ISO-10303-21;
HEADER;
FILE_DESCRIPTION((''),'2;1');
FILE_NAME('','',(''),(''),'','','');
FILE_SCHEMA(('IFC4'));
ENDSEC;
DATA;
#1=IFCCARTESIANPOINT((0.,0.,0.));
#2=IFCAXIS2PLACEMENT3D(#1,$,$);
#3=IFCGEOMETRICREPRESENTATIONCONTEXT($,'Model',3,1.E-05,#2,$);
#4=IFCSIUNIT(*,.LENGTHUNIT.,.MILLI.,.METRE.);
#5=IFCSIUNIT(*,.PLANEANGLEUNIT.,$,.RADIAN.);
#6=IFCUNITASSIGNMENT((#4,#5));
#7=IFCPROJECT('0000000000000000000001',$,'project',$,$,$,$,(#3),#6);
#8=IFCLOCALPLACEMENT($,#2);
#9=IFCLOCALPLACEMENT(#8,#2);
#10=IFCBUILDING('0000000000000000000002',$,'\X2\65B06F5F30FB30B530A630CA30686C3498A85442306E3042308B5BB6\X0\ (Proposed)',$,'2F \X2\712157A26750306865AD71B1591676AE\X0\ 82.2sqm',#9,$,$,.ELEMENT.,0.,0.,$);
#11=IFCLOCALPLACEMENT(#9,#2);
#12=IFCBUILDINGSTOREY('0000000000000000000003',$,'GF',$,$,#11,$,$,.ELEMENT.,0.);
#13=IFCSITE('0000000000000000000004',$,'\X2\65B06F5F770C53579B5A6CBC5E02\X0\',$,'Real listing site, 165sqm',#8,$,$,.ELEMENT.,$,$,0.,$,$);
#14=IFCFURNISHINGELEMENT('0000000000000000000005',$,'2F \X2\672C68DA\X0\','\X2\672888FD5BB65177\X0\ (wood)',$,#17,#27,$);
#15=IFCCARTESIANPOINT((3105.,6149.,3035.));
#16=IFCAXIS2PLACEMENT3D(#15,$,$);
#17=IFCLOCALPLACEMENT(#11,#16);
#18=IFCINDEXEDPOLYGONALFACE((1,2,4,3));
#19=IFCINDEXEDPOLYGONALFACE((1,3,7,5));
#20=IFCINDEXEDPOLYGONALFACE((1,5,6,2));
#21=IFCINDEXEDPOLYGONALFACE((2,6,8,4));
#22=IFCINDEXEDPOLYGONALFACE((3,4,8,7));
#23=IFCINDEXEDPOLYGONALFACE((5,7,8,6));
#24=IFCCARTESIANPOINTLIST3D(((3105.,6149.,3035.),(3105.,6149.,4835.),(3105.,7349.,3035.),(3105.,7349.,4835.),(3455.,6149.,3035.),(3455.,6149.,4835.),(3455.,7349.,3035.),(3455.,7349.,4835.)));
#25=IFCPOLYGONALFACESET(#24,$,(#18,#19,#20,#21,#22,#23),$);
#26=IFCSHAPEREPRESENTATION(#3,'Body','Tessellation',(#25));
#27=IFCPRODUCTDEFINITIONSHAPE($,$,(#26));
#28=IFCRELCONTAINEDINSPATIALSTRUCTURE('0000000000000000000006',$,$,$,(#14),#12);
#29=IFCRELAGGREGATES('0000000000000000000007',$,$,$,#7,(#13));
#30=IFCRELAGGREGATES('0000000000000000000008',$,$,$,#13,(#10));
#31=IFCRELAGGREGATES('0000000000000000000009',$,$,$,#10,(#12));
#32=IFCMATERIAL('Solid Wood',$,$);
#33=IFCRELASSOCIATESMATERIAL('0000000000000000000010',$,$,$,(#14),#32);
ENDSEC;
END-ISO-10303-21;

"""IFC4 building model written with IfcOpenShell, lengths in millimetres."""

from ifc_helpers import new_model, si_unit, frame, frame_2d, origin, place, context, project, spatial, rectangle, extrude, material, element, save


model = new_model("IFC4")

# Units and contexts
model_context = context("Model", 3, precision=1e-05, world=origin())
ifc_project = project(units=[si_unit("LENGTHUNIT", "METRE", prefix="MILLI"), si_unit("PLANEANGLEUNIT", "RADIAN")], contexts=[model_context])

# Site, building, storey
site_placement = place(None, origin())
site = spatial("IfcSite", under=ifc_project, at=site_placement, Name="新潟県南魚沼市", ObjectType="Real listing site, 165sqm", CompositionType="ELEMENT", RefElevation=0.0)
building_placement = place(site_placement, origin())
building = spatial("IfcBuilding", under=site, at=building_placement, Name="新潟・サウナと水風呂のある家 (Proposed)", ObjectType="2F 無垢材と断熱外皮 82.2sqm", CompositionType="ELEMENT", ElevationOfRefHeight=0.0, ElevationOfTerrain=0.0)
storey_placement = place(building_placement, origin())
storey = spatial("IfcBuildingStorey", under=building, at=storey_placement, Name="GF", CompositionType="ELEMENT", Elevation=0.0)

# Shared definitions
ifc_material_1 = material(Name="Solid Wood")

# Furnishing element
furnishing_placement = place(storey_placement, frame((3105.0, 6149.0, 3035.0)))
element("IfcFurnishingElement", 1, at=furnishing_placement, inside=storey, material=ifc_material_1, Name="2F 本棚", Description="木製家具 (wood)", context=model_context, shape_type="SweptSolid", body=[
    extrude(rectangle(XDim=350.0, YDim=1200.0, at=frame_2d((175.0, 600.0))), frame((3105.0, 6149.0, 3035.0)), (0.0, 0.0, 1.0), 1800.0),
])

save(model, "model.ifc")
